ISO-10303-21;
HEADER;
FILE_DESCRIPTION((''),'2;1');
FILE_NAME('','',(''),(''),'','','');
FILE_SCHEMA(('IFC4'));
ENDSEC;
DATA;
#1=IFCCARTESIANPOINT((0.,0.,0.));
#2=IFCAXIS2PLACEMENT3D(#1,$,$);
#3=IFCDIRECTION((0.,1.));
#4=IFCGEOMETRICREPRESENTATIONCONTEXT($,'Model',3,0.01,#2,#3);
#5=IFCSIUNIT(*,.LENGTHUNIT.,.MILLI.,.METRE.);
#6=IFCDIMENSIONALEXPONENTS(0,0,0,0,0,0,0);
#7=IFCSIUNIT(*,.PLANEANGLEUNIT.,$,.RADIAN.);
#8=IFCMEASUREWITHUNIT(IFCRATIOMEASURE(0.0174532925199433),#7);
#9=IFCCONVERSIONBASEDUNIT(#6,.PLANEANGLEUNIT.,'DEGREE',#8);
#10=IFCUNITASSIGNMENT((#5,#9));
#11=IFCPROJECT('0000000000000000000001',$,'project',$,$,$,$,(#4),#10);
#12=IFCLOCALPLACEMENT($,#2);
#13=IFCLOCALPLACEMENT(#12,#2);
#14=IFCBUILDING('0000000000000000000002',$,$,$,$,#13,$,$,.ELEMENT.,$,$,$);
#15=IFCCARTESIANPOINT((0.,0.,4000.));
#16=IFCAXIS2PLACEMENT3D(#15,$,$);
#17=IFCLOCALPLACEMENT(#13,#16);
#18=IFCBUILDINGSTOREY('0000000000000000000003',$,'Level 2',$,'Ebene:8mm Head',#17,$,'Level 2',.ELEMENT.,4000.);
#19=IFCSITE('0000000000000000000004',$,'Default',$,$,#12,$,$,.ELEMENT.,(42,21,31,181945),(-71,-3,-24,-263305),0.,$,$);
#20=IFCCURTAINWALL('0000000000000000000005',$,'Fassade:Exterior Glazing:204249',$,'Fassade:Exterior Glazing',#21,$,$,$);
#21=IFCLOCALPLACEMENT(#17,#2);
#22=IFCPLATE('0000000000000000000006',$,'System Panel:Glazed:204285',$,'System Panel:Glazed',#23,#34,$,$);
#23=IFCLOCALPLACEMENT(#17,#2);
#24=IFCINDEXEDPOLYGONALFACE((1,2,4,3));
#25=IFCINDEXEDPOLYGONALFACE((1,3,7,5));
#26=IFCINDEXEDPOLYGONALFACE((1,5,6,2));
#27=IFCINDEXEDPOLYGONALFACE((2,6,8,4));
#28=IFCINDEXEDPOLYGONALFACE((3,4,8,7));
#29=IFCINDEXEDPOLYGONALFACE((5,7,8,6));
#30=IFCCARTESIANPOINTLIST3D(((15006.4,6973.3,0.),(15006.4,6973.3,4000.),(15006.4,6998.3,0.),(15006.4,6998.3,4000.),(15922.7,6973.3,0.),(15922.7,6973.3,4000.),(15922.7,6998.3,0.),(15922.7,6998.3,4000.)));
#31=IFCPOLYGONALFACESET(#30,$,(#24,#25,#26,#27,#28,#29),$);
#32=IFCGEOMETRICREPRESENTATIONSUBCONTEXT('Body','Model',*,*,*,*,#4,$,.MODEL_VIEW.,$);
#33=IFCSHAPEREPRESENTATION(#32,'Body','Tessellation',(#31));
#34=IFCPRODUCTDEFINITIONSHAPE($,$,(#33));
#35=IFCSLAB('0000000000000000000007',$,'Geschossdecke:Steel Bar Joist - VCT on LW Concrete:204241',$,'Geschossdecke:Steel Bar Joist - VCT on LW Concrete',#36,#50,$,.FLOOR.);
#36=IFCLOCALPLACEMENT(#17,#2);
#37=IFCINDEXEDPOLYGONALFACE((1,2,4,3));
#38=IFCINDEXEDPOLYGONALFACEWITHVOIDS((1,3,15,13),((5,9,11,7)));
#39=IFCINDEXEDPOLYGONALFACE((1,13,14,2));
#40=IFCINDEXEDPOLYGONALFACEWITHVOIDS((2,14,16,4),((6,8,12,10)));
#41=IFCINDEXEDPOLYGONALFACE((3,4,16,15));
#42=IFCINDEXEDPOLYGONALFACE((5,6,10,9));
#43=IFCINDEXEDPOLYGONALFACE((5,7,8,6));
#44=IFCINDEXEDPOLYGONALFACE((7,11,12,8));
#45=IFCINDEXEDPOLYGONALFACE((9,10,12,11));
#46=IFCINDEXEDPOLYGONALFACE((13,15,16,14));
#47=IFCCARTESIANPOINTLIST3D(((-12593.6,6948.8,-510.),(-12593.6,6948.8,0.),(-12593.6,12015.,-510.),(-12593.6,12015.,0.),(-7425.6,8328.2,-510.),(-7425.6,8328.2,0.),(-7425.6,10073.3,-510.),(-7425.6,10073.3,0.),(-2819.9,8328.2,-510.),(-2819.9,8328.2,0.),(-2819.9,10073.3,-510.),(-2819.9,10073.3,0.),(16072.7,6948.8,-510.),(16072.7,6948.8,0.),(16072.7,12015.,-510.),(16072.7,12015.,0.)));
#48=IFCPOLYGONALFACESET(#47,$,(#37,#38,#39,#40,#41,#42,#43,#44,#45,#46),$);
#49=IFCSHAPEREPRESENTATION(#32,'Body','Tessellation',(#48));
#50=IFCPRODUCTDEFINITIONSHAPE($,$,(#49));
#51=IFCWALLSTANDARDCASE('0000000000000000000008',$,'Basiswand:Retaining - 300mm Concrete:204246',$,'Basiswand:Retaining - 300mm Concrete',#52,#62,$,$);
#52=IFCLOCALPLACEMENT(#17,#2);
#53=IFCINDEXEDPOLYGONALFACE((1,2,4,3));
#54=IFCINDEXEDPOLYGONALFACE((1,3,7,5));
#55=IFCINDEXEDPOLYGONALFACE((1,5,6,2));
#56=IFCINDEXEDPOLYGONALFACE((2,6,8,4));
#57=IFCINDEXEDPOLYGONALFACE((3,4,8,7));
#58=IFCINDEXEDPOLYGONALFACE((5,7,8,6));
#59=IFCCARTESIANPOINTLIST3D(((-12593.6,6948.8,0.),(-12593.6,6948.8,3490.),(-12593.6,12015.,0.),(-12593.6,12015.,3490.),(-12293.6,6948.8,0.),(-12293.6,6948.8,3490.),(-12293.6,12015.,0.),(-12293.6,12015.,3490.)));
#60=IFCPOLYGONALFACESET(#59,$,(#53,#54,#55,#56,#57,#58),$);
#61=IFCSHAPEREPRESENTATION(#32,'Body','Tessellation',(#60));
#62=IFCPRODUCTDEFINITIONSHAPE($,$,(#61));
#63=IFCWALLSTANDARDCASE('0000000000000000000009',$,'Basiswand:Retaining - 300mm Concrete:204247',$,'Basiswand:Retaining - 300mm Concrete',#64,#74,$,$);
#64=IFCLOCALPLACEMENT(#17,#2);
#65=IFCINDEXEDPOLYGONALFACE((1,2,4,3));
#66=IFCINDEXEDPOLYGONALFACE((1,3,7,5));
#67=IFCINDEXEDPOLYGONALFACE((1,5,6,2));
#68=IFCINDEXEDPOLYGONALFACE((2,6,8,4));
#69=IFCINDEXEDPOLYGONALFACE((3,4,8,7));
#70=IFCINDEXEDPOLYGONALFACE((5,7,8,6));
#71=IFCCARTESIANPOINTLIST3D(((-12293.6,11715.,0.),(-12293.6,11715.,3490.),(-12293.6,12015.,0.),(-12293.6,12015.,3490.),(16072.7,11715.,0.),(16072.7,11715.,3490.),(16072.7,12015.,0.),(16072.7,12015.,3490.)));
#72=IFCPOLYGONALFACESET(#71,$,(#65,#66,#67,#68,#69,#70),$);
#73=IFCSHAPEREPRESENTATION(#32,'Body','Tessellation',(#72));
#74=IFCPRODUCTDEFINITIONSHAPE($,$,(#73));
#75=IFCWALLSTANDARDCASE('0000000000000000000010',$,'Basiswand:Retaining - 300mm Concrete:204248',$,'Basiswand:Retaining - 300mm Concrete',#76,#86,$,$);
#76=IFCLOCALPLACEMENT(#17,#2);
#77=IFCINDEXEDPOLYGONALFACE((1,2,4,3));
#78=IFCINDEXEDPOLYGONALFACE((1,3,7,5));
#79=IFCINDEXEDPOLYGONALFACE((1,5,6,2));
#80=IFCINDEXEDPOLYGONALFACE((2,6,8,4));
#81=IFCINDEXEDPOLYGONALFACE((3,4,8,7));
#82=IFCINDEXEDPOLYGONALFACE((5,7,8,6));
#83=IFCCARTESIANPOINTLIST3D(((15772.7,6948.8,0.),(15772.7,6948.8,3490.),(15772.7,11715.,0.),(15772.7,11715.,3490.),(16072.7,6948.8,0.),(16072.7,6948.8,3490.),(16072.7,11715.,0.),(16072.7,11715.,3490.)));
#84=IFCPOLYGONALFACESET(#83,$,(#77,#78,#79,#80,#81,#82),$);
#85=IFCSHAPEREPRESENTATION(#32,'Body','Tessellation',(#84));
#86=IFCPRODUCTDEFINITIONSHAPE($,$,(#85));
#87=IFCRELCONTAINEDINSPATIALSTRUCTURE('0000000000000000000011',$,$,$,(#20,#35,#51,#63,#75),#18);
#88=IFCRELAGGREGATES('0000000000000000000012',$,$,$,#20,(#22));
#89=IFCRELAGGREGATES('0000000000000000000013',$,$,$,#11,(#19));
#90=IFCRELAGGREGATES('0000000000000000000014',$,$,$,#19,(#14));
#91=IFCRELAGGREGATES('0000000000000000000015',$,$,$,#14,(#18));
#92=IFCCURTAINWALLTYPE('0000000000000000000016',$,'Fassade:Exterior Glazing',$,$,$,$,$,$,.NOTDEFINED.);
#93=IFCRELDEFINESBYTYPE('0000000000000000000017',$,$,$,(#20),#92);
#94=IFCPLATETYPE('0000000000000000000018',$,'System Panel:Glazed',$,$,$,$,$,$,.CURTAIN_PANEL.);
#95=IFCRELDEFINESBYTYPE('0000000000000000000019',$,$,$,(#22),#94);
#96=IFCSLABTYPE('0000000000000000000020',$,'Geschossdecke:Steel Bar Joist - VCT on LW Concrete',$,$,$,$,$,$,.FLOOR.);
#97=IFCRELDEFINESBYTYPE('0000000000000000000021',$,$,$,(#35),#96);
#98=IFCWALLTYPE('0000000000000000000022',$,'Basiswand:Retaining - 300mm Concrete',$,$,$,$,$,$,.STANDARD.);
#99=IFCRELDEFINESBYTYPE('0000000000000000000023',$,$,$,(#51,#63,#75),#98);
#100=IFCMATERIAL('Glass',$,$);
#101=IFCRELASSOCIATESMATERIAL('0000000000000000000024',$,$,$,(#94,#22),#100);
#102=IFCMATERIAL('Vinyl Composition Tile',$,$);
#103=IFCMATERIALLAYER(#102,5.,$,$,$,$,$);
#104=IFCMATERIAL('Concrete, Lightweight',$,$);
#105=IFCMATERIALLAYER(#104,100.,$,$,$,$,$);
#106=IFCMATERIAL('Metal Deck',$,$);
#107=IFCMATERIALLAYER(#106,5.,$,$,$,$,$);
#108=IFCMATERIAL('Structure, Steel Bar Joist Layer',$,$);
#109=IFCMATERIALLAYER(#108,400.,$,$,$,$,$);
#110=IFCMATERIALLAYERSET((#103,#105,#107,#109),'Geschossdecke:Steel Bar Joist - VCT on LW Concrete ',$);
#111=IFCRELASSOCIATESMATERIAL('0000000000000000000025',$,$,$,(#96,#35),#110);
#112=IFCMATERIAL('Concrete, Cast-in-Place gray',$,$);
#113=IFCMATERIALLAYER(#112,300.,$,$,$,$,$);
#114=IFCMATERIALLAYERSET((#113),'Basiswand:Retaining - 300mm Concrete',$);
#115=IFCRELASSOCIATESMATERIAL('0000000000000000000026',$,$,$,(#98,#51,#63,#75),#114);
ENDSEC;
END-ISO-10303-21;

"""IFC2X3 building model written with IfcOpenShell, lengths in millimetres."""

from ifc_helpers import new_model, entity, si_unit, converted_unit, direction, frame, frame_2d, origin, origin_2d_with_axis, place, context, subcontext, project, spatial, polyline, rectangle, extrude, clip, bounded_halfspace, source, transform, mapped, material, layer, layer_set, layer_usage, type_object, type_shapes, element, aggregate, save


model = new_model("IFC2X3")

# Units and contexts
model_context = context("Model", 3, precision=0.01, world=origin(), true_north=direction((0.0, 1.0)))
body_context = subcontext(model_context, "Body", "Model", "MODEL_VIEW")
ifc_project = project(units=[si_unit("LENGTHUNIT", "METRE", prefix="MILLI"), converted_unit("PLANEANGLEUNIT", "DEGREE", entity("IfcRatioMeasure", 0.0174532925199433), si_unit("PLANEANGLEUNIT", "RADIAN"), dimensions=[0, 0, 0, 0, 0, 0, 0])], contexts=[model_context])

# Site, building, storey
site_placement = place(None, origin())
site = spatial("IfcSite", under=ifc_project, at=site_placement, Name="Default", CompositionType="ELEMENT", RefLatitude=(42, 21, 31, 181945), RefLongitude=(-71, -3, -24, -263305), RefElevation=0.0)
building_placement = place(site_placement, origin())
building = spatial("IfcBuilding", under=site, at=building_placement, CompositionType="ELEMENT")
storey_placement = place(building_placement, frame((0.0, 0.0, 4000.0)))
storey = spatial("IfcBuildingStorey", under=building, at=storey_placement, Name="Level 2", ObjectType="Ebene:8mm Head", LongName="Level 2", CompositionType="ELEMENT", Elevation=4000.0)

# Curtain wall, plate
curtain_wall_type = type_object("IfcCurtainWallType", Name="Fassade:Exterior Glazing", PredefinedType="NOTDEFINED")
curtain_wall_placement = place(storey_placement, frame((0.0, 0.0, -4000.0)))
curtain_wall = element("IfcCurtainWall", 1, at=curtain_wall_placement, inside=storey, type_object=curtain_wall_type, Name="Fassade:Exterior Glazing:204249", ObjectType="Fassade:Exterior Glazing")
ifc_material_1 = material(Name="Glass")
plate_type_1 = type_object("IfcPlateType", Name="System Panel:Glazed", PredefinedType="CURTAIN_PANEL", material=ifc_material_1)
shared_shape_1 = source(origin(), body_context, "Body", "SweptSolid", [
    extrude(rectangle(XDim=25.0, YDim=916.3, at=origin_2d_with_axis()), frame((0.0, 37.0, 0.0), z_axis=(0.0, 0.0, 1.0), x_axis=(0.0, 1.0, 0.0)), (0.0, 0.0, 1.0), 4000.0),
])
type_shapes(plate_type_1, [shared_shape_1])
plate_1_placement = place(curtain_wall_placement, frame((15464.6, 6948.8, 4000.0)))
plate_1 = element("IfcPlate", 2, at=plate_1_placement, type_object=plate_type_1, material=ifc_material_1, Name="System Panel:Glazed:204285", ObjectType="System Panel:Glazed", context=body_context, shape_type="MappedRepresentation", body=[
    mapped(shared_shape_1, transform((0.0, 0.0, 0.0), scale=1.0)),
])
aggregate(curtain_wall, [plate_1])

# Slab, opening
ifc_material_2 = material(Name="Vinyl Composition Tile")
ifc_layer_1 = layer(ifc_material_2, 5.0)
ifc_material_3 = material(Name="Concrete, Lightweight")
ifc_layer_2 = layer(ifc_material_3, 100.0)
ifc_material_4 = material(Name="Metal Deck")
ifc_layer_3 = layer(ifc_material_4, 5.0)
ifc_material_5 = material(Name="Structure, Steel Bar Joist Layer")
ifc_layer_4 = layer(ifc_material_5, 400.0)
ifc_layer_set_1 = layer_set([ifc_layer_1, ifc_layer_2, ifc_layer_3, ifc_layer_4], Name="Geschossdecke:Steel Bar Joist - VCT on LW Concrete ")
ifc_layer_usage_1 = layer_usage(ifc_layer_set_1, "AXIS3", "POSITIVE", 0.0)
slab_type = type_object("IfcSlabType", Name="Geschossdecke:Steel Bar Joist - VCT on LW Concrete", PredefinedType="FLOOR", material=ifc_layer_set_1)
slab_placement = place(storey_placement, frame((-12593.6, 6948.8, -510.0)))
slab = element("IfcSlab", 3, at=slab_placement, inside=storey, type_object=slab_type, material=ifc_layer_usage_1, Name="Geschossdecke:Steel Bar Joist - VCT on LW Concrete:204241", ObjectType="Geschossdecke:Steel Bar Joist - VCT on LW Concrete", PredefinedType="FLOOR", context=body_context, shape_type="SweptSolid", body=[
    extrude(rectangle(XDim=5066.3, YDim=28666.3, at=frame_2d((0.0, 0.0), x_axis=(0.0, -1.0))), frame((14333.1, 2533.1, 510.0), z_axis=(0.0, 0.0, -1.0), x_axis=(-1.0, 0.0, 0.0)), (0.0, 0.0, 1.0), 510.0),
])
opening_placement = place(slab_placement, frame((7470.8, 2252.0, 510.0)))
element("IfcOpeningElement", 4, at=opening_placement, cuts=slab, ObjectType="Opening", context=body_context, shape_type="SweptSolid", body=[
    extrude(rectangle(XDim=4605.8, YDim=1745.1, at=origin_2d_with_axis()), frame((0.0, 0.0, 0.0), z_axis=(0.0, 0.0, -1.0), x_axis=(1.0, 0.0, 0.0)), (0.0, 0.0, 1.0), 510.0),
])

# Walls
ifc_material_6 = material(Name="Concrete, Cast-in-Place gray")
ifc_layer_5 = layer(ifc_material_6, 300.0)
ifc_layer_set_2 = layer_set([ifc_layer_5], Name="Basiswand:Retaining - 300mm Concrete")
ifc_layer_usage_2 = layer_usage(ifc_layer_set_2, "AXIS2", "NEGATIVE", 150.0)
wall_type = type_object("IfcWallType", Name="Basiswand:Retaining - 300mm Concrete", PredefinedType="STANDARD", material=ifc_layer_set_2)
wall_1_placement = place(storey_placement, frame((-12443.6, 6948.8, 0.0), z_axis=(0.0, 0.0, 1.0), x_axis=(0.0, 1.0, 0.0)))
element("IfcWallStandardCase", 5, at=wall_1_placement, inside=storey, type_object=wall_type, material=ifc_layer_usage_2, Name="Basiswand:Retaining - 300mm Concrete:204246", ObjectType="Basiswand:Retaining - 300mm Concrete", context=body_context, shape_type="Clipping", body=[
    clip(extrude(rectangle(XDim=5066.3, YDim=300.0, at=frame_2d((2533.1, 0.0), x_axis=(-1.0, 0.0))), origin(), (0.0, 0.0, 1.0), 3490.0), bounded_halfspace(frame((0.0, -150.0, 3490.0), z_axis=(0.0, 0.0, -1.0), x_axis=(-1.0, 0.0, 0.0)), True, frame((0.0, -150.0, 3490.0)), polyline([(0.0, 0.0), (4766.3, 0.0), (5066.3, 0.0), (5066.3, 300.0), (0.0, 300.0), (0.0, 0.0)]))),
])
ifc_layer_usage_3 = layer_usage(ifc_layer_set_2, "AXIS2", "NEGATIVE", 150.0)
wall_2_placement = place(storey_placement, frame((-12293.6, 11865.0, 0.0)))
element("IfcWallStandardCase", 6, at=wall_2_placement, inside=storey, type_object=wall_type, material=ifc_layer_usage_3, Name="Basiswand:Retaining - 300mm Concrete:204247", ObjectType="Basiswand:Retaining - 300mm Concrete", context=body_context, shape_type="Clipping", body=[
    clip(extrude(rectangle(XDim=28366.3, YDim=300.0, at=frame_2d((14183.1, 0.0), x_axis=(-1.0, 0.0))), origin(), (0.0, 0.0, 1.0), 3490.0), bounded_halfspace(frame((0.0, -150.0, 3490.0), z_axis=(0.0, 0.0, -1.0), x_axis=(0.0, -1.0, 0.0)), True, frame((0.0, -150.0, 3490.0)), polyline([(0.0, 0.0), (28066.3, 0.0), (28366.3, 0.0), (28366.3, 300.0), (0.0, 300.0), (0.0, 0.0)]))),
])
ifc_layer_usage_4 = layer_usage(ifc_layer_set_2, "AXIS2", "NEGATIVE", 150.0)
wall_3_placement = place(storey_placement, frame((15922.7, 11715.0, 0.0), z_axis=(0.0, 0.0, 1.0), x_axis=(0.0, -1.0, 0.0)))
element("IfcWallStandardCase", 7, at=wall_3_placement, inside=storey, type_object=wall_type, material=ifc_layer_usage_4, Name="Basiswand:Retaining - 300mm Concrete:204248", ObjectType="Basiswand:Retaining - 300mm Concrete", context=body_context, shape_type="Clipping", body=[
    clip(extrude(rectangle(XDim=4766.3, YDim=300.0, at=frame_2d((2383.1, 0.0), x_axis=(-1.0, 0.0))), origin(), (0.0, 0.0, 1.0), 3490.0), bounded_halfspace(frame((0.0, -150.0, 3490.0), z_axis=(0.0, 0.0, -1.0), x_axis=(1.0, 0.0, 0.0)), True, frame((0.0, -150.0, 3490.0)), polyline([(0.0, 0.0), (4766.3, 0.0), (4766.3, 300.0), (0.0, 300.0), (0.0, 0.0)]))),
])

save(model, "model.ifc")
